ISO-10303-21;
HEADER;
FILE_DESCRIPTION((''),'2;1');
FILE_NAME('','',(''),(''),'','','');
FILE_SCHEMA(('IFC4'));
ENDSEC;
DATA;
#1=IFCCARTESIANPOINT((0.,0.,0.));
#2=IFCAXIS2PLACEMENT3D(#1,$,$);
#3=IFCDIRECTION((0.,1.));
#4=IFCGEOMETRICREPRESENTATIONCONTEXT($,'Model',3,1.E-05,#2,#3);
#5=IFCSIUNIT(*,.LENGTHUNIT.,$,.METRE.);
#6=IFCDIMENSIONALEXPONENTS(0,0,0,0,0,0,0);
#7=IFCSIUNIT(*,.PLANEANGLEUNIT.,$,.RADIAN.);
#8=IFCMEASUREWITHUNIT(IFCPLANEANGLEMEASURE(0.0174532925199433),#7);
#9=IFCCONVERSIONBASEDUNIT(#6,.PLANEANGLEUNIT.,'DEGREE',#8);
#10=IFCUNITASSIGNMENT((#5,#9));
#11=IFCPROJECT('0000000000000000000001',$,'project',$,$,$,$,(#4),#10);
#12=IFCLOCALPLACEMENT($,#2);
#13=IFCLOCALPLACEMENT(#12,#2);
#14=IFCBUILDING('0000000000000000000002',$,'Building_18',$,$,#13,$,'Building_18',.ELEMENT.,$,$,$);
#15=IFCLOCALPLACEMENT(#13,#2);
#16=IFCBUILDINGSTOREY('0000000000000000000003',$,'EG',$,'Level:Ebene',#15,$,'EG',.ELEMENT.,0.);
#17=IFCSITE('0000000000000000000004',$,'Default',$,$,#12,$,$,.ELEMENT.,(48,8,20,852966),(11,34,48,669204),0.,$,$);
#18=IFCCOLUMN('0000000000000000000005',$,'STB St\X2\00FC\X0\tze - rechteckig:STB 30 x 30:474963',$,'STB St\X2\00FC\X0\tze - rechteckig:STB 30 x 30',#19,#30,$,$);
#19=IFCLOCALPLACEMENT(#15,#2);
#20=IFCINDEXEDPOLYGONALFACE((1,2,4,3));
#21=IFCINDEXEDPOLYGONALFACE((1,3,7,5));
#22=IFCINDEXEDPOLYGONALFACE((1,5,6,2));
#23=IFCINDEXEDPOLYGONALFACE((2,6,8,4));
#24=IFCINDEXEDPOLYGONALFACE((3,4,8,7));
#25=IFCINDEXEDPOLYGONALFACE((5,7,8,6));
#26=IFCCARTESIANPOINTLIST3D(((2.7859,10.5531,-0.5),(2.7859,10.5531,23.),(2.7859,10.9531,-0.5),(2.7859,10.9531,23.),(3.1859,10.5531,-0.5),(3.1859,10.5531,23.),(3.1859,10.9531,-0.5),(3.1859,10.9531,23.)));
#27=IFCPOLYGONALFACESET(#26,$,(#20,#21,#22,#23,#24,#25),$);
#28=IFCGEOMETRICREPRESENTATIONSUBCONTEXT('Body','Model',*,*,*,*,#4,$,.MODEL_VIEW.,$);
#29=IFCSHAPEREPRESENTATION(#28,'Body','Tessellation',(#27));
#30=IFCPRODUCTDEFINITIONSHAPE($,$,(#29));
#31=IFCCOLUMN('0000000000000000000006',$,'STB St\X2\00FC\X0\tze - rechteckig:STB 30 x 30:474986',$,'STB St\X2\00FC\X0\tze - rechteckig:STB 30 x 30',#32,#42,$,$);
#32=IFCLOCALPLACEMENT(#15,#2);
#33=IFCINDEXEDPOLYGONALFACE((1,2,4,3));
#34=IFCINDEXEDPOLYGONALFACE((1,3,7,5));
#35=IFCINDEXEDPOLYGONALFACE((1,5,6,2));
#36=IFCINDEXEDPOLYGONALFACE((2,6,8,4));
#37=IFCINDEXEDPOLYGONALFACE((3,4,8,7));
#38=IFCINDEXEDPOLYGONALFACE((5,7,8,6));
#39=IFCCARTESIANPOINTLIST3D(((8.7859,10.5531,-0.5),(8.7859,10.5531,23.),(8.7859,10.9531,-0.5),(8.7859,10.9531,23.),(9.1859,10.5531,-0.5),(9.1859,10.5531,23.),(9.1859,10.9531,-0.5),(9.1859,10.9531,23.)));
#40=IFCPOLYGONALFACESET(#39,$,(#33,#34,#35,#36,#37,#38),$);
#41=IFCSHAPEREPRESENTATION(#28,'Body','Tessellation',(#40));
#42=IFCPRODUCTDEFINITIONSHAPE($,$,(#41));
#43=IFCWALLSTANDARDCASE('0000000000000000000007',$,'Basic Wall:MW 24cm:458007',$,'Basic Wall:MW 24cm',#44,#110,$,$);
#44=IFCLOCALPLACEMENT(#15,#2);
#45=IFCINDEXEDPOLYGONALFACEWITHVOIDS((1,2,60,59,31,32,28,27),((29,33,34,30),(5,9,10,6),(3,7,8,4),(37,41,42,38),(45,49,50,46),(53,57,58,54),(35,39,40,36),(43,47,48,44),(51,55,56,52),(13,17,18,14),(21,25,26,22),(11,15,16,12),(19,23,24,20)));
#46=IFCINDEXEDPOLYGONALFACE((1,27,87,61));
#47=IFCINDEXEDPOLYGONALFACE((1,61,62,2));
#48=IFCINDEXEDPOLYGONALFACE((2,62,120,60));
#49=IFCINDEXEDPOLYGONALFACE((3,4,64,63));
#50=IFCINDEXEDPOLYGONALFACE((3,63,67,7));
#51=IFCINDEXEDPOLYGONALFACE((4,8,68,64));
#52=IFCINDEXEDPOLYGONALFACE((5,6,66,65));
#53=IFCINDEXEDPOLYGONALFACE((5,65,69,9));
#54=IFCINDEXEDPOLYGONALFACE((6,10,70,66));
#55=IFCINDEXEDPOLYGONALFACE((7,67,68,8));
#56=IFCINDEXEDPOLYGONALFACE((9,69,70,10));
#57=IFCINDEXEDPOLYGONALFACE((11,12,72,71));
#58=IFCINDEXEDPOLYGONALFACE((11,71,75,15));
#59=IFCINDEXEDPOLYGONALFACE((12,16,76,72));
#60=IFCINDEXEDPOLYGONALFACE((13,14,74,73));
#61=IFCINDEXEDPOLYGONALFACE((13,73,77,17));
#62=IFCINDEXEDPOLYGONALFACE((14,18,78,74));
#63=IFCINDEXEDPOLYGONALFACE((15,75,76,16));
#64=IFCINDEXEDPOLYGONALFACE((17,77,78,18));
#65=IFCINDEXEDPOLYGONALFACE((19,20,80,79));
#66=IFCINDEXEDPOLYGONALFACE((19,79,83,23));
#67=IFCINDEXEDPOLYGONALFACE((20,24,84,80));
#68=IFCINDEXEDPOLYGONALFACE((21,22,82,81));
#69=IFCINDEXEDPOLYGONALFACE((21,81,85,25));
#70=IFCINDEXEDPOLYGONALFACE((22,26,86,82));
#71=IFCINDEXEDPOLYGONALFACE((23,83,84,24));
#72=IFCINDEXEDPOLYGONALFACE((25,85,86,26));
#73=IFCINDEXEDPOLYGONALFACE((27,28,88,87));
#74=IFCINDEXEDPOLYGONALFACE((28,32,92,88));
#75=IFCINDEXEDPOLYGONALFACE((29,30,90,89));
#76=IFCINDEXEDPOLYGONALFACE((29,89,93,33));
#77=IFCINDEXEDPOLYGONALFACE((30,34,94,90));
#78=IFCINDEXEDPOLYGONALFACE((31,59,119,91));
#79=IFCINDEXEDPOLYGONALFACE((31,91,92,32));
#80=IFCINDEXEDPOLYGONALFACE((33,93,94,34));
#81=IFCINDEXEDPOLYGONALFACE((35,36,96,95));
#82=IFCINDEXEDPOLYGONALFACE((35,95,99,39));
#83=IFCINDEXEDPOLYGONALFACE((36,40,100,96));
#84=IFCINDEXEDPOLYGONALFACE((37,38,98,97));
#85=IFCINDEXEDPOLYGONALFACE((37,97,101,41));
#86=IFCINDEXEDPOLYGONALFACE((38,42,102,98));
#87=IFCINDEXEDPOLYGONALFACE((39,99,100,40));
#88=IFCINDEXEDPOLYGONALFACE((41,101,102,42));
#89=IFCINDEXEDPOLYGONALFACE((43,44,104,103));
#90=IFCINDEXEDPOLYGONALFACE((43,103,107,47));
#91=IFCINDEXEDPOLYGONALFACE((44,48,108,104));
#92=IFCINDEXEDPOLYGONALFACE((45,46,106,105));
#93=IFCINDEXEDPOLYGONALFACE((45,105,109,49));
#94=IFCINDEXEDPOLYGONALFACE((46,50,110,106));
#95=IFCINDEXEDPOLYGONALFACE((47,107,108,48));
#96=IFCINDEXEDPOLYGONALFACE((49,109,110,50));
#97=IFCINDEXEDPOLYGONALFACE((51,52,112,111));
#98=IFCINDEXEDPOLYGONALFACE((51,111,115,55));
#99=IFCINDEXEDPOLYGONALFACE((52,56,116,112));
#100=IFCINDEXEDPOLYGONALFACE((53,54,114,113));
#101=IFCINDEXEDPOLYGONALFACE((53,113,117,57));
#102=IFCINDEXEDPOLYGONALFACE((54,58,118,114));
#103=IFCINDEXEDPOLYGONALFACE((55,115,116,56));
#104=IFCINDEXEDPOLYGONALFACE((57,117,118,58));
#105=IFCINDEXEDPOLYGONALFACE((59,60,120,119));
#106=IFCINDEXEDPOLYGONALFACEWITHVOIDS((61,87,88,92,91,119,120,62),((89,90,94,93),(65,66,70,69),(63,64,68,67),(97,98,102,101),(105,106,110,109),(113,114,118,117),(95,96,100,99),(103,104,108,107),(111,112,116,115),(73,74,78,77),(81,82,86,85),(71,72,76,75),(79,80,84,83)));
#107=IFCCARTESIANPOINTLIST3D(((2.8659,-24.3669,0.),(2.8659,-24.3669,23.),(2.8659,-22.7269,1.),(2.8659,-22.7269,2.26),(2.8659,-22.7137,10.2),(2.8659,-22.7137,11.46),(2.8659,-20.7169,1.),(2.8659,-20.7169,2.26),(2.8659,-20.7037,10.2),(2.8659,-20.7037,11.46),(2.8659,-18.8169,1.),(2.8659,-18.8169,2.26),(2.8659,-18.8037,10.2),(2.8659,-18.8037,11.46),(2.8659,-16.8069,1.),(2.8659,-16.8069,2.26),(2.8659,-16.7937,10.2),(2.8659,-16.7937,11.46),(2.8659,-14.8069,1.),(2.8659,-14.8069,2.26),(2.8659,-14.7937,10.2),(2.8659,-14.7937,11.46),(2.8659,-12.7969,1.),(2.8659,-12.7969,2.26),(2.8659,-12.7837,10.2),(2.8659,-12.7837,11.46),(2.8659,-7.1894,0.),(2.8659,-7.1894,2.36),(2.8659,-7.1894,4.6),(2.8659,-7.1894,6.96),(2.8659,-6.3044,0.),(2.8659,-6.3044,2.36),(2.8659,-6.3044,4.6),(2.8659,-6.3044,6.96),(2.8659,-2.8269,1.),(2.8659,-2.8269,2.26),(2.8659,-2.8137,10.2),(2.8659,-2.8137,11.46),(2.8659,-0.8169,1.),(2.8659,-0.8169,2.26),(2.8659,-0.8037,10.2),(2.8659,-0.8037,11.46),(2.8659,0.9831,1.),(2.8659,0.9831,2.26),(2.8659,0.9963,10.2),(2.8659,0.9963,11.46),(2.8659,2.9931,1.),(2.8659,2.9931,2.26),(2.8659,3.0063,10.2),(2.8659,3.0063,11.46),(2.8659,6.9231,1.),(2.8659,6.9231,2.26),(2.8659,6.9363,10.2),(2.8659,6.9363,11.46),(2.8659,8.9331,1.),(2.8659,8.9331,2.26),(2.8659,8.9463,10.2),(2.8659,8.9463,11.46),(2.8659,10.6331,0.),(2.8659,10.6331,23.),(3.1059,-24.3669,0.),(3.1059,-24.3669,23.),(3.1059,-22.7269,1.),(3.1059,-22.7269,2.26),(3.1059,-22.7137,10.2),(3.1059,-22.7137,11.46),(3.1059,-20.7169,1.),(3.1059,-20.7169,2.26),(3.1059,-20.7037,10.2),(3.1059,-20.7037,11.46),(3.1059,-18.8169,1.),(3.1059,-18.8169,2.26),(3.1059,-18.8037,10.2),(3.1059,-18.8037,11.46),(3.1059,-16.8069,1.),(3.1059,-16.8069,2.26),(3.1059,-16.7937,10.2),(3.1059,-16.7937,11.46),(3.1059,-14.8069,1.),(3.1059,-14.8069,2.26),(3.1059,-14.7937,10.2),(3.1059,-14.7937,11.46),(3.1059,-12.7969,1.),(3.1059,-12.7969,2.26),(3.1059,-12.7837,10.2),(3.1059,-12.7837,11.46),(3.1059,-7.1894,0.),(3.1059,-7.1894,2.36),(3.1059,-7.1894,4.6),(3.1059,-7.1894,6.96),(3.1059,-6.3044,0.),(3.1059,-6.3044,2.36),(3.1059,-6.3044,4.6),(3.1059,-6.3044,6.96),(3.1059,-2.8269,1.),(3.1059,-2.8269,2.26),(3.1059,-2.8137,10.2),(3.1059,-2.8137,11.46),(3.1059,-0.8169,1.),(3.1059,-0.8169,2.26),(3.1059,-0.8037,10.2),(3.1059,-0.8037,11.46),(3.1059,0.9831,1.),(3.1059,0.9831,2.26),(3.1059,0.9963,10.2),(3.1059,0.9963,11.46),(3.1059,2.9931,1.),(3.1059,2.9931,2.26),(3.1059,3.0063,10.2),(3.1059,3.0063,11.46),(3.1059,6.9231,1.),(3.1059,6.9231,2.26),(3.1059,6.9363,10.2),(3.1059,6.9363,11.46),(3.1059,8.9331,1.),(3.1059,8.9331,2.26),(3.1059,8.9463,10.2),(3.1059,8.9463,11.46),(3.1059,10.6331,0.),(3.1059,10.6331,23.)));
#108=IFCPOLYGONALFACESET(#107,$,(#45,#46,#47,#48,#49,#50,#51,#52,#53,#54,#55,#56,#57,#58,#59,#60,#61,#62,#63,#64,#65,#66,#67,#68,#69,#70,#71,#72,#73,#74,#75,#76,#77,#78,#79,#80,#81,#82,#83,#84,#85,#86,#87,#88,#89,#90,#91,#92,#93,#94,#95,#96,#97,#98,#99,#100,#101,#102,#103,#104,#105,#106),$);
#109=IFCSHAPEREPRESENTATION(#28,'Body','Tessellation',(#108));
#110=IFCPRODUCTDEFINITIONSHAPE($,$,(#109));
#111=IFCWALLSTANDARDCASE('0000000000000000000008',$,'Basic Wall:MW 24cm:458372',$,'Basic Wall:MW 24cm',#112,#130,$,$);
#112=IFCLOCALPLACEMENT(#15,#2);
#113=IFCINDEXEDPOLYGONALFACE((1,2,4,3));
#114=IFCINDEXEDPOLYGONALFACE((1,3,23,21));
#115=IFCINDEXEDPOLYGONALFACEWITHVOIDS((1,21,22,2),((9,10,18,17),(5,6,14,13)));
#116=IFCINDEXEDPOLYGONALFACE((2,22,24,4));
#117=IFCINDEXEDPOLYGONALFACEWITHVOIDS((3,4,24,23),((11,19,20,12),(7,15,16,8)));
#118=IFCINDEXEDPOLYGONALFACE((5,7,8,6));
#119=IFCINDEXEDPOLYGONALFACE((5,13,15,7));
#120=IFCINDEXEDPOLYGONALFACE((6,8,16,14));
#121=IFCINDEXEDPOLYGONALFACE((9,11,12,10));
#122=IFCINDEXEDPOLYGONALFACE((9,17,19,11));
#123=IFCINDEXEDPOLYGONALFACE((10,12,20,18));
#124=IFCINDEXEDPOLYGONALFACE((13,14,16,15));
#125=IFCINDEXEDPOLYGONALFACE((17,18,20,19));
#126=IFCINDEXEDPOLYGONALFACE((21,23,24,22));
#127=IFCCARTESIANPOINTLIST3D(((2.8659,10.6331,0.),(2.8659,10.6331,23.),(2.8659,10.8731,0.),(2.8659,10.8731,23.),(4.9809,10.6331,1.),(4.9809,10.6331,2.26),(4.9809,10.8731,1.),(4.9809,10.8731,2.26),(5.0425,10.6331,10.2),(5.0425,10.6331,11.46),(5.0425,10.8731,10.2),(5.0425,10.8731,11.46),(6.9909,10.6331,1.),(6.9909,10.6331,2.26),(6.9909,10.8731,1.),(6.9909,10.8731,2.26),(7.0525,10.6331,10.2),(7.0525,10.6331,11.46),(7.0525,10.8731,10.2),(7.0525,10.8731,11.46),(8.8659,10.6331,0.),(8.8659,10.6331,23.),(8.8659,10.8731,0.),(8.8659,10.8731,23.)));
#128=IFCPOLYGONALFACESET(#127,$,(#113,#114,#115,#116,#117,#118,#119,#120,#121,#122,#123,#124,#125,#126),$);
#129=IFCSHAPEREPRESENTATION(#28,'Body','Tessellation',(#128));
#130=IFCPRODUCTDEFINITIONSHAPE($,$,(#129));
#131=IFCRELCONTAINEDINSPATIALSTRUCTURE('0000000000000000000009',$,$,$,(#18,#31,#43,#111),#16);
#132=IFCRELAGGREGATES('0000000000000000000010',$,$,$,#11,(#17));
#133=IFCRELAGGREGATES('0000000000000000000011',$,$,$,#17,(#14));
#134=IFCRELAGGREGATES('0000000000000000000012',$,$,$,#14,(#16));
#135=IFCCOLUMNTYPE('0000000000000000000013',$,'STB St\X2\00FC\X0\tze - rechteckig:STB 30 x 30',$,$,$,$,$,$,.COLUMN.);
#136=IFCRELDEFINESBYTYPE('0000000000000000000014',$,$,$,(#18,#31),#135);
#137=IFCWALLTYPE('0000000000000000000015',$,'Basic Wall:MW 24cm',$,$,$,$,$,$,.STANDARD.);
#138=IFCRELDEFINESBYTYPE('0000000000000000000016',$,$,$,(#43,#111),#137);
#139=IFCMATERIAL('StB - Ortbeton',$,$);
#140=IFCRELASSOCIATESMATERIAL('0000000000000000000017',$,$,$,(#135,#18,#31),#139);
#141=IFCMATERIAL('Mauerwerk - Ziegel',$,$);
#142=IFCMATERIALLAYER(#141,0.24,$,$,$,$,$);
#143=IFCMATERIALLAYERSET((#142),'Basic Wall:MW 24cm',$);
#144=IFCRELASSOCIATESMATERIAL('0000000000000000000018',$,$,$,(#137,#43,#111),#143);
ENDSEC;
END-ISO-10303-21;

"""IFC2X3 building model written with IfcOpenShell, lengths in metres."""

from ifc_helpers import new_model, entity, si_unit, converted_unit, direction, frame, frame_2d, origin, origin_2d_with_axis, place, context, subcontext, project, spatial, rectangle, extrude, source, transform, mapped, material, layer, layer_set, layer_usage, type_object, type_shapes, element, save


model = new_model("IFC2X3")

# Units and contexts
model_context = context("Model", 3, precision=1e-05, world=origin(), true_north=direction((0.0, 1.0)))
body_context = subcontext(model_context, "Body", "Model", "MODEL_VIEW")
ifc_project = project(units=[si_unit("LENGTHUNIT", "METRE"), converted_unit("PLANEANGLEUNIT", "DEGREE", entity("IfcPlaneAngleMeasure", 0.0174532925199433), si_unit("PLANEANGLEUNIT", "RADIAN"), dimensions=[0, 0, 0, 0, 0, 0, 0])], contexts=[model_context])

# Site, building, storey
site_placement = place(None, origin())
site = spatial("IfcSite", under=ifc_project, at=site_placement, Name="Default", CompositionType="ELEMENT", RefLatitude=(48, 8, 20, 852966), RefLongitude=(11, 34, 48, 669204), RefElevation=0.0)
building_placement = place(site_placement, origin())
building = spatial("IfcBuilding", under=site, at=building_placement, Name="Building_18", LongName="Building_18", CompositionType="ELEMENT")
storey_placement = place(building_placement, origin())
storey = spatial("IfcBuildingStorey", under=building, at=storey_placement, Name="EG", ObjectType="Level:Ebene", LongName="EG", CompositionType="ELEMENT", Elevation=0.0)

# Columns
ifc_material_1 = material(Name="StB - Ortbeton")
column_type = type_object("IfcColumnType", Name="STB Stütze - rechteckig:STB 30 x 30", PredefinedType="COLUMN", material=ifc_material_1)
shared_shape = source(origin(), body_context, "Body", "SweptSolid", [
    extrude(rectangle(XDim=0.4, YDim=0.4, at=origin_2d_with_axis()), frame((0.0, 0.0, -0.5), z_axis=(0.0, 0.0, 1.0), x_axis=(-1.0, 0.0, 0.0)), (0.0, 0.0, 1.0), 23.5),
])
type_shapes(column_type, [shared_shape])
for number, where, name in (
    (1, (2.9859, 10.7531, 0.0), "STB Stütze - rechteckig:STB 30 x 30:474963"),
    (2, (8.9859, 10.7531, 0.0), "STB Stütze - rechteckig:STB 30 x 30:474986"),
):
    element("IfcColumn", number, at=place(storey_placement, frame(where)), inside=storey, type_object=column_type, material=ifc_material_1, Name=name, ObjectType="STB Stütze - rechteckig:STB 30 x 30", context=body_context, shape_type="MappedRepresentation", body=[
        mapped(shared_shape, transform((0.0, 0.0, 0.0), scale=1.0)),
    ])

# Walls, openings
ifc_material_2 = material(Name="Mauerwerk - Ziegel")
ifc_layer = layer(ifc_material_2, 0.24)
ifc_layer_set = layer_set([ifc_layer], Name="Basic Wall:MW 24cm")
ifc_layer_usage_1 = layer_usage(ifc_layer_set, "AXIS2", "NEGATIVE", 0.12)
wall_type = type_object("IfcWallType", Name="Basic Wall:MW 24cm", PredefinedType="STANDARD", material=ifc_layer_set)
wall_1_placement = place(storey_placement, frame((2.9859, 10.6331, 0.0), z_axis=(0.0, 0.0, 1.0), x_axis=(0.0, -1.0, 0.0)))
wall_1 = element("IfcWallStandardCase", 3, at=wall_1_placement, inside=storey, type_object=wall_type, material=ifc_layer_usage_1, Name="Basic Wall:MW 24cm:458007", ObjectType="Basic Wall:MW 24cm", context=body_context, shape_type="SweptSolid", body=[
    extrude(rectangle(XDim=35.0, YDim=0.24, at=frame_2d((17.5, 0.0), x_axis=(1.0, 0.0))), origin(), (0.0, 0.0, 1.0), 23.0),
])
opening_1_placement = place(wall_1_placement, frame((17.8225, 0.12, 0.0)))
element("IfcOpeningElement", 4, at=opening_1_placement, cuts=wall_1, ObjectType="Opening", context=body_context, shape_type="SweptSolid", body=[
    extrude(rectangle(XDim=2.36, YDim=0.885, at=frame_2d((1.18, 0.4425), x_axis=(1.0, 0.0))), frame((0.0, 0.0, 0.0), z_axis=(0.0, -1.0, 0.0), x_axis=(0.0, 0.0, 1.0)), (0.0, 0.0, 1.0), 0.24),
])
opening_2_placement = place(wall_1_placement, frame((13.46, 0.12, 1.0)))
element("IfcOpeningElement", 5, at=opening_2_placement, cuts=wall_1, ObjectType="Opening", context=body_context, shape_type="SweptSolid", body=[
    extrude(rectangle(XDim=1.26, YDim=2.01, at=frame_2d((0.63, 1.005), x_axis=(1.0, 0.0))), frame((0.0, 0.0, 0.0), z_axis=(0.0, -1.0, 0.0), x_axis=(0.0, 0.0, 1.0)), (0.0, 0.0, 1.0), 0.24),
])
opening_3_placement = place(wall_1_placement, frame((9.65, 0.12, 1.0)))
element("IfcOpeningElement", 6, at=opening_3_placement, cuts=wall_1, ObjectType="Opening", context=body_context, shape_type="SweptSolid", body=[
    extrude(rectangle(XDim=1.26, YDim=2.01, at=frame_2d((0.63, 1.005), x_axis=(1.0, 0.0))), frame((0.0, 0.0, 0.0), z_axis=(0.0, -1.0, 0.0), x_axis=(0.0, 0.0, 1.0)), (0.0, 0.0, 1.0), 0.24),
])
opening_4_placement = place(wall_1_placement, frame((1.7, -0.12, 1.0)))
element("IfcOpeningElement", 7, at=opening_4_placement, cuts=wall_1, ObjectType="Opening", context=body_context, shape_type="SweptSolid", body=[
    extrude(rectangle(XDim=1.26, YDim=2.01, at=frame_2d((0.63, 1.005), x_axis=(1.0, 0.0))), frame((0.0, 0.0, 0.0), z_axis=(0.0, 1.0, 0.0), x_axis=(0.0, 0.0, 1.0)), (0.0, 0.0, 1.0), 0.24),
])
opening_5_placement = place(wall_1_placement, frame((31.35, -0.12, 1.0)))
element("IfcOpeningElement", 8, at=opening_5_placement, cuts=wall_1, ObjectType="Opening", context=body_context, shape_type="SweptSolid", body=[
    extrude(rectangle(XDim=1.26, YDim=2.01, at=frame_2d((0.63, 1.005), x_axis=(1.0, 0.0))), frame((0.0, 0.0, 0.0), z_axis=(0.0, 1.0, 0.0), x_axis=(0.0, 0.0, 1.0)), (0.0, 0.0, 1.0), 0.24),
])
opening_6_placement = place(wall_1_placement, frame((27.44, -0.12, 1.0)))
element("IfcOpeningElement", 9, at=opening_6_placement, cuts=wall_1, ObjectType="Opening", context=body_context, shape_type="SweptSolid", body=[
    extrude(rectangle(XDim=1.26, YDim=2.01, at=frame_2d((0.63, 1.005), x_axis=(1.0, 0.0))), frame((0.0, 0.0, 0.0), z_axis=(0.0, 1.0, 0.0), x_axis=(0.0, 0.0, 1.0)), (0.0, 0.0, 1.0), 0.24),
])
opening_7_placement = place(wall_1_placement, frame((25.44, 0.12, 1.0)))
element("IfcOpeningElement", 10, at=opening_7_placement, cuts=wall_1, ObjectType="Opening", context=body_context, shape_type="SweptSolid", body=[
    extrude(rectangle(XDim=1.26, YDim=2.01, at=frame_2d((0.63, 1.005), x_axis=(1.0, 0.0))), frame((0.0, 0.0, 0.0), z_axis=(0.0, -1.0, 0.0), x_axis=(0.0, 0.0, 1.0)), (0.0, 0.0, 1.0), 0.24),
])
opening_8_placement = place(wall_1_placement, frame((13.4468, 0.12, 10.2)))
element("IfcOpeningElement", 11, at=opening_8_placement, cuts=wall_1, ObjectType="Opening", context=body_context, shape_type="SweptSolid", body=[
    extrude(rectangle(XDim=1.26, YDim=2.01, at=frame_2d((0.63, 1.005), x_axis=(1.0, 0.0))), frame((0.0, 0.0, 0.0), z_axis=(0.0, -1.0, 0.0), x_axis=(0.0, 0.0, 1.0)), (0.0, 0.0, 1.0), 0.24),
])
opening_9_placement = place(wall_1_placement, frame((9.6368, 0.12, 10.2)))
element("IfcOpeningElement", 12, at=opening_9_placement, cuts=wall_1, ObjectType="Opening", context=body_context, shape_type="SweptSolid", body=[
    extrude(rectangle(XDim=1.26, YDim=2.01, at=frame_2d((0.63, 1.005), x_axis=(1.0, 0.0))), frame((0.0, 0.0, 0.0), z_axis=(0.0, -1.0, 0.0), x_axis=(0.0, 0.0, 1.0)), (0.0, 0.0, 1.0), 0.24),
])
opening_10_placement = place(wall_1_placement, frame((1.6868, -0.12, 10.2)))
element("IfcOpeningElement", 13, at=opening_10_placement, cuts=wall_1, ObjectType="Opening", context=body_context, shape_type="SweptSolid", body=[
    extrude(rectangle(XDim=1.26, YDim=2.01, at=frame_2d((0.63, 1.005), x_axis=(1.0, 0.0))), frame((0.0, 0.0, 0.0), z_axis=(0.0, 1.0, 0.0), x_axis=(0.0, 0.0, 1.0)), (0.0, 0.0, 1.0), 0.24),
])
opening_11_placement = place(wall_1_placement, frame((31.3368, -0.12, 10.2)))
element("IfcOpeningElement", 14, at=opening_11_placement, cuts=wall_1, ObjectType="Opening", context=body_context, shape_type="SweptSolid", body=[
    extrude(rectangle(XDim=1.26, YDim=2.01, at=frame_2d((0.63, 1.005), x_axis=(1.0, 0.0))), frame((0.0, 0.0, 0.0), z_axis=(0.0, 1.0, 0.0), x_axis=(0.0, 0.0, 1.0)), (0.0, 0.0, 1.0), 0.24),
])
opening_12_placement = place(wall_1_placement, frame((27.4268, -0.12, 10.2)))
element("IfcOpeningElement", 15, at=opening_12_placement, cuts=wall_1, ObjectType="Opening", context=body_context, shape_type="SweptSolid", body=[
    extrude(rectangle(XDim=1.26, YDim=2.01, at=frame_2d((0.63, 1.005), x_axis=(1.0, 0.0))), frame((0.0, 0.0, 0.0), z_axis=(0.0, 1.0, 0.0), x_axis=(0.0, 0.0, 1.0)), (0.0, 0.0, 1.0), 0.24),
])
opening_13_placement = place(wall_1_placement, frame((25.4268, 0.12, 10.2)))
element("IfcOpeningElement", 16, at=opening_13_placement, cuts=wall_1, ObjectType="Opening", context=body_context, shape_type="SweptSolid", body=[
    extrude(rectangle(XDim=1.26, YDim=2.01, at=frame_2d((0.63, 1.005), x_axis=(1.0, 0.0))), frame((0.0, 0.0, 0.0), z_axis=(0.0, -1.0, 0.0), x_axis=(0.0, 0.0, 1.0)), (0.0, 0.0, 1.0), 0.24),
])
opening_14_placement = place(wall_1_placement, frame((17.8225, 0.12, 4.6)))
element("IfcOpeningElement", 17, at=opening_14_placement, cuts=wall_1, ObjectType="Opening", context=body_context, shape_type="SweptSolid", body=[
    extrude(rectangle(XDim=2.36, YDim=0.885, at=frame_2d((1.18, 0.4425), x_axis=(1.0, 0.0))), frame((0.0, 0.0, 0.0), z_axis=(0.0, -1.0, 0.0), x_axis=(0.0, 0.0, 1.0)), (0.0, 0.0, 1.0), 0.24),
])
ifc_layer_usage_2 = layer_usage(ifc_layer_set, "AXIS2", "NEGATIVE", 0.12)
wall_2_placement = place(storey_placement, frame((8.8659, 10.7531, 0.0), z_axis=(0.0, 0.0, 1.0), x_axis=(-1.0, 0.0, 0.0)))
wall_2 = element("IfcWallStandardCase", 18, at=wall_2_placement, inside=storey, type_object=wall_type, material=ifc_layer_usage_2, Name="Basic Wall:MW 24cm:458372", ObjectType="Basic Wall:MW 24cm", context=body_context, shape_type="SweptSolid", body=[
    extrude(rectangle(XDim=6.0, YDim=0.24, at=frame_2d((3.0, 0.0), x_axis=(-1.0, 0.0))), origin(), (0.0, 0.0, 1.0), 23.0),
])
opening_15_placement = place(wall_2_placement, frame((3.885, 0.12, 1.0)))
element("IfcOpeningElement", 19, at=opening_15_placement, cuts=wall_2, ObjectType="Opening", context=body_context, shape_type="SweptSolid", body=[
    extrude(rectangle(XDim=1.26, YDim=2.01, at=frame_2d((0.63, 1.005), x_axis=(1.0, 0.0))), frame((0.0, 0.0, 0.0), z_axis=(0.0, -1.0, 0.0), x_axis=(0.0, 0.0, 1.0)), (0.0, 0.0, 1.0), 0.24),
])
opening_16_placement = place(wall_2_placement, frame((3.8235, 0.12, 10.2)))
element("IfcOpeningElement", 20, at=opening_16_placement, cuts=wall_2, ObjectType="Opening", context=body_context, shape_type="SweptSolid", body=[
    extrude(rectangle(XDim=1.26, YDim=2.01, at=frame_2d((0.63, 1.005), x_axis=(1.0, 0.0))), frame((0.0, 0.0, 0.0), z_axis=(0.0, -1.0, 0.0), x_axis=(0.0, 0.0, 1.0)), (0.0, 0.0, 1.0), 0.24),
])

save(model, "model.ifc")
